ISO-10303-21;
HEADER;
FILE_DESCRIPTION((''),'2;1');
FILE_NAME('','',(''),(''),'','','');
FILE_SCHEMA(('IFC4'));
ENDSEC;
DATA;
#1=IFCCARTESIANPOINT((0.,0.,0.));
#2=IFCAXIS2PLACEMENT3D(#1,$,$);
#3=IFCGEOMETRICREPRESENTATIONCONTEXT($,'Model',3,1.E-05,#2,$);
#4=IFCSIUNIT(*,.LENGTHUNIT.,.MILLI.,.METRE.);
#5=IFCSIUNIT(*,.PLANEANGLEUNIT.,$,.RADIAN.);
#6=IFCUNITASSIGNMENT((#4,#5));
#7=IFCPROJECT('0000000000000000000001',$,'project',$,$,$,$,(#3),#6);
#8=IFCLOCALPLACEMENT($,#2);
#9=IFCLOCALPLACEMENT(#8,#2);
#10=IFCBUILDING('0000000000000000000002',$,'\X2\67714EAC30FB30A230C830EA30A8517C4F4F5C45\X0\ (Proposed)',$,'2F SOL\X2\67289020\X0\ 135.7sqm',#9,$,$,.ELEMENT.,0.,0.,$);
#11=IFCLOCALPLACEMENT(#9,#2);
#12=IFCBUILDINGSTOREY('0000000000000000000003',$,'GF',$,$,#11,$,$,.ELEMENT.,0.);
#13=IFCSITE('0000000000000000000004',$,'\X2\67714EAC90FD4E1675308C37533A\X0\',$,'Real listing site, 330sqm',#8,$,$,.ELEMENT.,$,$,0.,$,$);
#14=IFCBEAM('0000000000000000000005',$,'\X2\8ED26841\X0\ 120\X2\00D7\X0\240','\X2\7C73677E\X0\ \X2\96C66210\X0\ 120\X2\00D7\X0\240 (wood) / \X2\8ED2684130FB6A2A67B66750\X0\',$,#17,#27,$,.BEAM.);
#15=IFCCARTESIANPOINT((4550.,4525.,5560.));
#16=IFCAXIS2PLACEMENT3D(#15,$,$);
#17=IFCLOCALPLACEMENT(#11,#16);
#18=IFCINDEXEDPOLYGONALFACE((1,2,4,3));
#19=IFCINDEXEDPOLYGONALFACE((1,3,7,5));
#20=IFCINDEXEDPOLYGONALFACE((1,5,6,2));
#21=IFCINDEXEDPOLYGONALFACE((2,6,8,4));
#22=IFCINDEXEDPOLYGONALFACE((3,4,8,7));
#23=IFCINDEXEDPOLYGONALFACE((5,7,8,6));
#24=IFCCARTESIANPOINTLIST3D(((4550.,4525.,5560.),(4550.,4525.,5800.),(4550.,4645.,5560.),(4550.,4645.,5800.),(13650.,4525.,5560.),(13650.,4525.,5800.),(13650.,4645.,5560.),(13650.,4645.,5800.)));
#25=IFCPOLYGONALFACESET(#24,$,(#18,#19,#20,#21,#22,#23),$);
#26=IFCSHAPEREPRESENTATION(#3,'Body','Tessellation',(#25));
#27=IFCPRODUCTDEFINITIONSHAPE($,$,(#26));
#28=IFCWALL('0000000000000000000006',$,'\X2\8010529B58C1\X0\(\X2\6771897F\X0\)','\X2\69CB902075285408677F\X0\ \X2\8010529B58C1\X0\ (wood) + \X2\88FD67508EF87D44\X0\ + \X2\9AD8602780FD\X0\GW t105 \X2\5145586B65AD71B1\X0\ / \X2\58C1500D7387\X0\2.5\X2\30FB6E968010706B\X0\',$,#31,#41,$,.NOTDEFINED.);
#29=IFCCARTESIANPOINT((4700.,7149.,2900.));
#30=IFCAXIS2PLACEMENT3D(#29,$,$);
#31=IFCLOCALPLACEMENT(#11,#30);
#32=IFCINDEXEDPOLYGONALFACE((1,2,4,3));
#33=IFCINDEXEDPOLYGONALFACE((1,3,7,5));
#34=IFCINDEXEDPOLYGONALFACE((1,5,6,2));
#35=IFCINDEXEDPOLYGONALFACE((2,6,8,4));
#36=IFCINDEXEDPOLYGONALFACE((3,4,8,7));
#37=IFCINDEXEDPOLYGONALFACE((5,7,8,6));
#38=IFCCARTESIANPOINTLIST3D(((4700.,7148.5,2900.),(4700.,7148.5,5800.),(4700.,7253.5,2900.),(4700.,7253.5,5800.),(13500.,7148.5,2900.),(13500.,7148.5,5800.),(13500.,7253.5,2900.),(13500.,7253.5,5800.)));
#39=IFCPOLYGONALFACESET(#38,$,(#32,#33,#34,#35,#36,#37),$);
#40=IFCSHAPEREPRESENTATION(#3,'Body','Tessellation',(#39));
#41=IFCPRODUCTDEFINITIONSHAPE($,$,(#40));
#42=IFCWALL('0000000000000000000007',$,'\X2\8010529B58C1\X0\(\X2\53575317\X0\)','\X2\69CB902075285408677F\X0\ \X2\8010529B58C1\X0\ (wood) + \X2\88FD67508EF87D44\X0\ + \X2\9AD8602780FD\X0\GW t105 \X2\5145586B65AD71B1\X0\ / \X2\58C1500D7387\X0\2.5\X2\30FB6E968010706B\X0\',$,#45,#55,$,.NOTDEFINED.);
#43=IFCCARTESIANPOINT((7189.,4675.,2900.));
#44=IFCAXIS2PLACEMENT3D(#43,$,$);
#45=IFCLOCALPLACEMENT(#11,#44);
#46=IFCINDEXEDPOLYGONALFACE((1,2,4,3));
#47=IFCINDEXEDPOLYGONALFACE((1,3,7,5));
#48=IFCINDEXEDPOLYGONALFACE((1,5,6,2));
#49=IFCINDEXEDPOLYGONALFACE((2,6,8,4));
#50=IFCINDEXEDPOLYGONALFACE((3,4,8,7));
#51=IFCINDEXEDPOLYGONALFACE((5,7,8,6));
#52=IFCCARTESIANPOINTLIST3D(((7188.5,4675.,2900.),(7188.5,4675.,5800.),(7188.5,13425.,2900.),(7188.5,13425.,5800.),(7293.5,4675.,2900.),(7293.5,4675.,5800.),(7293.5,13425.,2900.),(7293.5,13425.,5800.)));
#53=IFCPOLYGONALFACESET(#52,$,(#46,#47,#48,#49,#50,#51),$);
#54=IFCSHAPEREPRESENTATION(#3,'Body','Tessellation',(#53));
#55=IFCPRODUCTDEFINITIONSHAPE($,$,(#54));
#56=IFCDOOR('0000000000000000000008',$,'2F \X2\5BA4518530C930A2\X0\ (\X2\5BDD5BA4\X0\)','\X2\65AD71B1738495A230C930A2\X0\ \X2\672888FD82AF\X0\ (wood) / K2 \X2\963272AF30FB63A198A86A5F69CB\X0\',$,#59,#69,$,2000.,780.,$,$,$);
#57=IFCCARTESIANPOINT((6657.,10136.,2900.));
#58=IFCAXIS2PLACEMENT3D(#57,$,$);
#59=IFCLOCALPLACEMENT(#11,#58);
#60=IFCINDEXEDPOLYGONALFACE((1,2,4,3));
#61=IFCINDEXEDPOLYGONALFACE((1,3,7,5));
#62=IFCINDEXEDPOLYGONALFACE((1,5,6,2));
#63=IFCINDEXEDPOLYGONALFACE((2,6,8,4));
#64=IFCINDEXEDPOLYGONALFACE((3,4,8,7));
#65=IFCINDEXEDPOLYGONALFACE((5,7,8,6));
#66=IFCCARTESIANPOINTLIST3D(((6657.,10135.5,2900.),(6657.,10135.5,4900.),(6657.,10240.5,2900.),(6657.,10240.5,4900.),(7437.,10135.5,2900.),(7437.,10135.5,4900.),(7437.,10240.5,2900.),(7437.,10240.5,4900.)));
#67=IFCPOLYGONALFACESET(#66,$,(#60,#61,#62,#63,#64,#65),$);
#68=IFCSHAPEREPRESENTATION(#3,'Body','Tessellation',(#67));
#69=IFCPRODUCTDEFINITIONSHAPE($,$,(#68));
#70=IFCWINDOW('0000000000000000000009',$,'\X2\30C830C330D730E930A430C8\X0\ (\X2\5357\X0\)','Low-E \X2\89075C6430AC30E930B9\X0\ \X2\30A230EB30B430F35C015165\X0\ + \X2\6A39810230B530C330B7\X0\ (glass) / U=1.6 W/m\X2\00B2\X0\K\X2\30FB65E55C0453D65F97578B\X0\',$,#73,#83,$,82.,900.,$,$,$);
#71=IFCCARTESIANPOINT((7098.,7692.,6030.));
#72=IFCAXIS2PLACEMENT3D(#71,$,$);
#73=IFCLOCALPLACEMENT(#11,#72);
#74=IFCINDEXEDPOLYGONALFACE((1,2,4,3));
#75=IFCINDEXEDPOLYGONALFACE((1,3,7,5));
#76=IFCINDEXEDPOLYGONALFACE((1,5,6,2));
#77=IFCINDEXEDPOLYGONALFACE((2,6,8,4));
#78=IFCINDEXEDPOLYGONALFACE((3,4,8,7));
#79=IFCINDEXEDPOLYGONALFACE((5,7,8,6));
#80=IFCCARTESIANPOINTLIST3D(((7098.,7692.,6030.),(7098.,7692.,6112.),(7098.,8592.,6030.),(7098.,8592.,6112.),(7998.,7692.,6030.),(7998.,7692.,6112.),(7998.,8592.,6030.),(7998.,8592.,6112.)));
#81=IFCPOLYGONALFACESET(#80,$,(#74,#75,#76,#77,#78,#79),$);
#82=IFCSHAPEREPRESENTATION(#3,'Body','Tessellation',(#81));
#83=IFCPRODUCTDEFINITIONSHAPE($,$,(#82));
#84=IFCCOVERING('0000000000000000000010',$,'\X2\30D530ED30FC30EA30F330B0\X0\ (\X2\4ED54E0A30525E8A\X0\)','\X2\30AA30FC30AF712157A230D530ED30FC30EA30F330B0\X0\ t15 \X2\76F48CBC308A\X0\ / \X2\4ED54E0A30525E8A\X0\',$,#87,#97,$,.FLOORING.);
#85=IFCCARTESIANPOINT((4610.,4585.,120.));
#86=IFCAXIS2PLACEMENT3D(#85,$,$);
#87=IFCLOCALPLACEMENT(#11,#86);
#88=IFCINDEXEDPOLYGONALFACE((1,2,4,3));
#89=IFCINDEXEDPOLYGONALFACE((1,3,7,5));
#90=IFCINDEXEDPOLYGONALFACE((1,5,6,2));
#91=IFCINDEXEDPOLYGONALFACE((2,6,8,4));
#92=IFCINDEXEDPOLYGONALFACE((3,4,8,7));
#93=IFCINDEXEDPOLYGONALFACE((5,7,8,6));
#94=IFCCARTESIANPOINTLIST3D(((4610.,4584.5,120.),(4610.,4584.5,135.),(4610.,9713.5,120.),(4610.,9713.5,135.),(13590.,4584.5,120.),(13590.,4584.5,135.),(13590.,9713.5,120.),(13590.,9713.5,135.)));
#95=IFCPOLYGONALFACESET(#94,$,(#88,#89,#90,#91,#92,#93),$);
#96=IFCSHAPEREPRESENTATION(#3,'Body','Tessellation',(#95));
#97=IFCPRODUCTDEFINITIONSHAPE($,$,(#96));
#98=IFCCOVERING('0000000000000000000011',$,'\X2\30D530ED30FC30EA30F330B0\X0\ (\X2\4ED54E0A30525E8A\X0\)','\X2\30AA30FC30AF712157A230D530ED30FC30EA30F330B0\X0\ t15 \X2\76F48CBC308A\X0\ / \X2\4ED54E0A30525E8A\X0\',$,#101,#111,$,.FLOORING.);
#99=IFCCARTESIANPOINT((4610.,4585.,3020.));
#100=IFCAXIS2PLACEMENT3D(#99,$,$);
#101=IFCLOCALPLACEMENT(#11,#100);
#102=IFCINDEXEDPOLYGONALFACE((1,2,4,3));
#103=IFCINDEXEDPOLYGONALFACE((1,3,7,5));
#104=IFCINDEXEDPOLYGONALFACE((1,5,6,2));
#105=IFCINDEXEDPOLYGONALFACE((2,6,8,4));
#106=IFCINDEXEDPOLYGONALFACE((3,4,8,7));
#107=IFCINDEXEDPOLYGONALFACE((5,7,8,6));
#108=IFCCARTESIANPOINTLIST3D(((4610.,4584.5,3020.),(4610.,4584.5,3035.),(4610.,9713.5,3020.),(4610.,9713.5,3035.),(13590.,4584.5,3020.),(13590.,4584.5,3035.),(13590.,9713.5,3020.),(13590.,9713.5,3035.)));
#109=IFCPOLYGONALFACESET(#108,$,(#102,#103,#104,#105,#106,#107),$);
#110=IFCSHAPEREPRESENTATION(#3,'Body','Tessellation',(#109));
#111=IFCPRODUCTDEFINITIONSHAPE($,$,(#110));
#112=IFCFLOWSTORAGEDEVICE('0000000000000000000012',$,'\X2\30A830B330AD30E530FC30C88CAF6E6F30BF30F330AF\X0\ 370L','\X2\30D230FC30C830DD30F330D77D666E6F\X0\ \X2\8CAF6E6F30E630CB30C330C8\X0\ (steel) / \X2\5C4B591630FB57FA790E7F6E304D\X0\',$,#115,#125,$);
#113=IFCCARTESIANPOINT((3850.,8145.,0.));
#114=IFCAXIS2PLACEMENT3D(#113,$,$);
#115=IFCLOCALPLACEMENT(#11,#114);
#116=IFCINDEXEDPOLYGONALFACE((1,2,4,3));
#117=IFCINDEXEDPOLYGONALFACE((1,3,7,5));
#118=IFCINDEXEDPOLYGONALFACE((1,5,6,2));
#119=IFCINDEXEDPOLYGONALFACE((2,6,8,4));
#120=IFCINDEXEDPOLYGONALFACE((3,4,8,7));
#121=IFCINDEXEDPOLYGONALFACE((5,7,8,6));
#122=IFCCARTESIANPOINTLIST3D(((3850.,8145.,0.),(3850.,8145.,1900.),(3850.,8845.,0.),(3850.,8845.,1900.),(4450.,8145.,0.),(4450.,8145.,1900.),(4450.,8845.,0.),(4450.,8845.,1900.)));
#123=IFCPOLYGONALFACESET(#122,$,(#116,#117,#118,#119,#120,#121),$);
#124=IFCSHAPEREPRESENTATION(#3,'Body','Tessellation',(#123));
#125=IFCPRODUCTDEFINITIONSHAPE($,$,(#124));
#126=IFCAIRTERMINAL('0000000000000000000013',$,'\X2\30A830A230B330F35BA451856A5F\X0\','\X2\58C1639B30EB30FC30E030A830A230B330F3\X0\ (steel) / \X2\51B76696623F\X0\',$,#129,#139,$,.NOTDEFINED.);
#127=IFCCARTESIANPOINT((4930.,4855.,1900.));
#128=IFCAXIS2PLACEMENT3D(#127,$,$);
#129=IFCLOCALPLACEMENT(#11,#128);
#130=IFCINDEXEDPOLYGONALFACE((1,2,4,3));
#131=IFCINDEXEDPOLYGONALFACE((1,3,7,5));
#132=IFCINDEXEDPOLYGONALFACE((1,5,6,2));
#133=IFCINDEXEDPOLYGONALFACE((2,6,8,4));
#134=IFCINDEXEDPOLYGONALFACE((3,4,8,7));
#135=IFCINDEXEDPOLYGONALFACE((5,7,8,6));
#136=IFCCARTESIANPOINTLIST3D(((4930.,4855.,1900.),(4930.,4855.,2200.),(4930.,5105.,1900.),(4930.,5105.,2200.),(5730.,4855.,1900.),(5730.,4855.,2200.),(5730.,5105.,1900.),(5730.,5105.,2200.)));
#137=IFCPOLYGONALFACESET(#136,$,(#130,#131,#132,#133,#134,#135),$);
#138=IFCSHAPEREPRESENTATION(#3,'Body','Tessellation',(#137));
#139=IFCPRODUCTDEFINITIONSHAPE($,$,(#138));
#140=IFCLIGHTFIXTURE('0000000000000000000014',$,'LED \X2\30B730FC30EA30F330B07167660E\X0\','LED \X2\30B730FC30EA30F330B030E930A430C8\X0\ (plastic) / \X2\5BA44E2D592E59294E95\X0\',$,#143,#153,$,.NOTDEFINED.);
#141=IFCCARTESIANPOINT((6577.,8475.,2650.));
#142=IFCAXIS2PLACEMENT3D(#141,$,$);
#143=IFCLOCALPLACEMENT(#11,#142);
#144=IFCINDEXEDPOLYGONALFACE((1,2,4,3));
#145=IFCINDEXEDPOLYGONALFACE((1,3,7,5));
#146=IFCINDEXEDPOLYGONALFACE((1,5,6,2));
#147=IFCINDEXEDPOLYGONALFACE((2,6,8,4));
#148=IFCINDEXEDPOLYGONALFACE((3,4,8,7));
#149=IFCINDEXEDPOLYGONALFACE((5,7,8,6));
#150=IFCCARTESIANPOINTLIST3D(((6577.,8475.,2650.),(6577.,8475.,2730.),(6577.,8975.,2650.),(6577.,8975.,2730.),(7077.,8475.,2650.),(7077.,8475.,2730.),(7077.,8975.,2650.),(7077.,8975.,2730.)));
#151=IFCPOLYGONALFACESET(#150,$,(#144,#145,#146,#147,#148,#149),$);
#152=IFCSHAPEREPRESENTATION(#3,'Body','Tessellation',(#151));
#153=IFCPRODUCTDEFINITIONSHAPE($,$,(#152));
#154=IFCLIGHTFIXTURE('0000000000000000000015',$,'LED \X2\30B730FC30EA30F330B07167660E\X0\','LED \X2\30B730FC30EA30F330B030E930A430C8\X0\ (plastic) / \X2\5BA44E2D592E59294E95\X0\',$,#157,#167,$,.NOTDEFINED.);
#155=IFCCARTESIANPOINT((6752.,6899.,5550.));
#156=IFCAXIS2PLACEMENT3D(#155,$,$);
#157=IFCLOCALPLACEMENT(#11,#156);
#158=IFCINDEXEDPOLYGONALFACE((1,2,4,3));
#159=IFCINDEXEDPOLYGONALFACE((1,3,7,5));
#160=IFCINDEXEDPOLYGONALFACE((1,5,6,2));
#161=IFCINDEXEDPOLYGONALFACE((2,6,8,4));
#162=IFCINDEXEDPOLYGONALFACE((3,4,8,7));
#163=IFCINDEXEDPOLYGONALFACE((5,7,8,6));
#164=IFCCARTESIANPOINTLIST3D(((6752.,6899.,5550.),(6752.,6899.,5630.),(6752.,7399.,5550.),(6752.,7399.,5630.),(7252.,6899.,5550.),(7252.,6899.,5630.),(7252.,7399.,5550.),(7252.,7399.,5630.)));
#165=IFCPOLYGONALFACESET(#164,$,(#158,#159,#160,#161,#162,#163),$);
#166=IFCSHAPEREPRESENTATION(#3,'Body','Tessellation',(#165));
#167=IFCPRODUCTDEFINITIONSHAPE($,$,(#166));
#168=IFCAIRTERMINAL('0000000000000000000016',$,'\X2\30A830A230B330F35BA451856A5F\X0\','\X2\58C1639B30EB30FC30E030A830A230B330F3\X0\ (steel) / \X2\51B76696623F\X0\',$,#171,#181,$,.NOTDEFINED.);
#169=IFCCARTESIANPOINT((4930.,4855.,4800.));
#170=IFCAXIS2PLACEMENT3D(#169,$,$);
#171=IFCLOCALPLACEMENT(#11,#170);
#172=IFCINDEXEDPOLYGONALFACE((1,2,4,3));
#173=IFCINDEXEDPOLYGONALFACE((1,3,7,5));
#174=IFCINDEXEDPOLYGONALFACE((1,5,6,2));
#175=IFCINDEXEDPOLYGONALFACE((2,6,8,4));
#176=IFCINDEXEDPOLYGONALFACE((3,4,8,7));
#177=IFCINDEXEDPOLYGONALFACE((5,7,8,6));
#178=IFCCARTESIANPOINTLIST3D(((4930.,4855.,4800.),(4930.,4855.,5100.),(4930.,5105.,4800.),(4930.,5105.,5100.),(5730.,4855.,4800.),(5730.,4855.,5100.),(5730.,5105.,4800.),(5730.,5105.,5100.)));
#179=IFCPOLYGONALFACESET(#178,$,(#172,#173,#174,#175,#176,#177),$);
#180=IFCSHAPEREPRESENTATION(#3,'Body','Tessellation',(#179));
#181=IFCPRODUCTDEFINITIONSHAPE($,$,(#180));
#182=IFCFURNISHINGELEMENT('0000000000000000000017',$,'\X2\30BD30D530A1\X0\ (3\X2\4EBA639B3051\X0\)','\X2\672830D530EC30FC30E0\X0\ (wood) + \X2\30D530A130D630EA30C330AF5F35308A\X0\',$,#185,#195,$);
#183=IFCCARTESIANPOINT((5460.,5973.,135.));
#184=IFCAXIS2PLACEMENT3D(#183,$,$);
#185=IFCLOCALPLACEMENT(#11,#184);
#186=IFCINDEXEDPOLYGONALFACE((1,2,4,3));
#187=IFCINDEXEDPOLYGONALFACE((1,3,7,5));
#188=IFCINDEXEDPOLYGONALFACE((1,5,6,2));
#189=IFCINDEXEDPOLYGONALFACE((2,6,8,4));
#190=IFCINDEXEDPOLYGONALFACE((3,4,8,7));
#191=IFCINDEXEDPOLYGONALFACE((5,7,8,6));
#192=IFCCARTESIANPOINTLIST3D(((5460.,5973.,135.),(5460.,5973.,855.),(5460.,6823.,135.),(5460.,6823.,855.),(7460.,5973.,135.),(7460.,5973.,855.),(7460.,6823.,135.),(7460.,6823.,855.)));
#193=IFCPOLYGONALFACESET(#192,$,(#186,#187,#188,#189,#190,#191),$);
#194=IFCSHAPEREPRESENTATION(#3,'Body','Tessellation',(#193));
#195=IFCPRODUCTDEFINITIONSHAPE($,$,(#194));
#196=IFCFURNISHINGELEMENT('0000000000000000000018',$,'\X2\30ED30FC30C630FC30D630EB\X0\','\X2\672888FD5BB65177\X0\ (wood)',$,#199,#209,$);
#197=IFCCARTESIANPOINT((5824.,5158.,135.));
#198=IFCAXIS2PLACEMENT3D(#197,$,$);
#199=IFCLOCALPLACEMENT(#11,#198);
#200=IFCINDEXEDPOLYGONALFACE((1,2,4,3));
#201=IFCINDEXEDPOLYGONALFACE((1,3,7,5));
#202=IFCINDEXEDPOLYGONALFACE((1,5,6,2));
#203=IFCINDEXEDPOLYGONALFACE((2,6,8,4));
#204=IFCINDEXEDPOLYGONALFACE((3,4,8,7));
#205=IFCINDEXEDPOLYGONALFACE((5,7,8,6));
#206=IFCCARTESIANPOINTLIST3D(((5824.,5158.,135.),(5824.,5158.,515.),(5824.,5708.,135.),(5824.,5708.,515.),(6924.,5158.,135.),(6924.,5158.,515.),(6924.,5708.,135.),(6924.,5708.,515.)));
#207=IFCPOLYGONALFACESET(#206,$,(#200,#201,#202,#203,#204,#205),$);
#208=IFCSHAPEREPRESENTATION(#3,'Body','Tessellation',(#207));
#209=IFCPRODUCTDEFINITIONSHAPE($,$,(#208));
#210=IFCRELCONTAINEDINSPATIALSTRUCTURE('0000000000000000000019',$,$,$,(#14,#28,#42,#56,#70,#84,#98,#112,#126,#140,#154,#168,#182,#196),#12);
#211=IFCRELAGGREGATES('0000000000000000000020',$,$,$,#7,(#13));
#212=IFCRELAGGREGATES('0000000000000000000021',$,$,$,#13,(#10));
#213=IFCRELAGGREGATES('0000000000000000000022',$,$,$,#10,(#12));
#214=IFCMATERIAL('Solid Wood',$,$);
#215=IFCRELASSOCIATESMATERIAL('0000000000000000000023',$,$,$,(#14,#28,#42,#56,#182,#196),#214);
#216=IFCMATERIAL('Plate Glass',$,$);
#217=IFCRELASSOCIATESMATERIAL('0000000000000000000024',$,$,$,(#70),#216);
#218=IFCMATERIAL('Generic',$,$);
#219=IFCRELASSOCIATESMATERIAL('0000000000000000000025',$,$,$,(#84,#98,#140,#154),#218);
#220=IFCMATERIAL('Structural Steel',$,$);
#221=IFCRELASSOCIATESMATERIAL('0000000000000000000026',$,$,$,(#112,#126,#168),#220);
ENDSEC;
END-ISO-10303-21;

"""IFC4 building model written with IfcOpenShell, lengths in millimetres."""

from ifc_helpers import new_model, si_unit, frame, frame_2d, origin, place, context, project, spatial, rectangle, extrude, material, element, fill, save


model = new_model("IFC4")

# Units and contexts
model_context = context("Model", 3, precision=1e-05, world=origin())
ifc_project = project(units=[si_unit("LENGTHUNIT", "METRE", prefix="MILLI"), si_unit("PLANEANGLEUNIT", "RADIAN")], contexts=[model_context])

# Site, building, storey
site_placement = place(None, origin())
site = spatial("IfcSite", under=ifc_project, at=site_placement, Name="東京都世田谷区", ObjectType="Real listing site, 330sqm", CompositionType="ELEMENT", RefElevation=0.0)
building_placement = place(site_placement, origin())
building = spatial("IfcBuilding", under=site, at=building_placement, Name="東京・アトリエ兼住居 (Proposed)", ObjectType="2F SOL木造 135.7sqm", CompositionType="ELEMENT", ElevationOfRefHeight=0.0, ElevationOfTerrain=0.0)
storey_placement = place(building_placement, origin())
storey = spatial("IfcBuildingStorey", under=building, at=storey_placement, Name="GF", CompositionType="ELEMENT", Elevation=0.0)

# Shared definitions
ifc_material_1 = material(Name="Solid Wood")

# Beam
beam_placement = place(storey_placement, frame((4550.0, 4525.0, 5560.0)))
element("IfcBeam", 1, at=beam_placement, inside=storey, material=ifc_material_1, Name="軒桁 120×240", Description="米松 集成 120×240 (wood) / 軒桁・横架材", PredefinedType="BEAM", context=model_context, shape_type="SweptSolid", body=[
    extrude(rectangle(XDim=9100.0, YDim=120.0, at=frame_2d((4550.0, 60.0))), frame((4550.0, 4525.0, 5560.0)), (0.0, 0.0, 1.0), 240.0),
])

# Wall
wall_1_placement = place(storey_placement, frame((4700.0, 7149.0, 2900.0)))
element("IfcWall", 2, at=wall_1_placement, inside=storey, material=ifc_material_1, Name="耐力壁(東西)", Description="構造用合板 耐力壁 (wood) + 製材軸組 + 高性能GW t105 充填断熱 / 壁倍率2.5・準耐火", PredefinedType="NOTDEFINED", context=model_context, shape_type="SweptSolid", body=[
    extrude(rectangle(XDim=8800.0, YDim=105.0, at=frame_2d((4400.0, 52.0))), frame((4700.0, 7149.0, 2900.0)), (0.0, 0.0, 1.0), 2900.0),
])

# Wall, opening, door
wall_2_placement = place(storey_placement, frame((7189.0, 4675.0, 2900.0)))
wall_2 = element("IfcWall", 3, at=wall_2_placement, inside=storey, material=ifc_material_1, Name="耐力壁(南北)", Description="構造用合板 耐力壁 (wood) + 製材軸組 + 高性能GW t105 充填断熱 / 壁倍率2.5・準耐火", PredefinedType="NOTDEFINED", context=model_context, shape_type="SweptSolid", body=[
    extrude(rectangle(XDim=105.0, YDim=8750.0, at=frame_2d((52.0, 4375.0))), frame((7189.0, 4675.0, 2900.0)), (0.0, 0.0, 1.0), 2900.0),
])
opening_1_placement = place(storey_placement, frame((6657.0, 10136.0, 2900.0)))
opening_1 = element("IfcOpeningElement", 4, at=opening_1_placement, cuts=wall_2, PredefinedType="NOTDEFINED", context=model_context, shape_type="SweptSolid", body=[
    extrude(rectangle(XDim=780.0, YDim=105.0, at=frame_2d((390.0, 52.0))), frame((6657.0, 10136.0, 2900.0)), (0.0, 0.0, 1.0), 2000.0),
])
door_1_placement = place(storey_placement, frame((6657.0, 10136.0, 2900.0)))
door_1 = element("IfcDoor", 5, at=door_1_placement, inside=storey, material=ifc_material_1, Name="2F 室内ドア (寝室)", Description="断熱玄関ドア 木製芯 (wood) / K2 防犯・採風機構", OverallHeight=2000.0, OverallWidth=780.0, context=model_context, shape_type="SweptSolid", body=[
    extrude(rectangle(XDim=780.0, YDim=105.0, at=frame_2d((390.0, 52.0))), frame((6657.0, 10136.0, 2900.0)), (0.0, 0.0, 1.0), 2000.0),
])
fill(opening_1, door_1)

# Window
ifc_material_2 = material(Name="Plate Glass")
window_placement = place(storey_placement, frame((7098.0, 7692.0, 6030.0)))
element("IfcWindow", 6, at=window_placement, inside=storey, material=ifc_material_2, Name="トップライト (南)", Description="Low-E 複層ガラス アルゴン封入 + 樹脂サッシ (glass) / U=1.6 W/m²K・日射取得型", OverallHeight=82.0, OverallWidth=900.0, context=model_context, shape_type="SweptSolid", body=[
    extrude(rectangle(XDim=900.0, YDim=900.0, at=frame_2d((450.0, 450.0))), frame((7098.0, 7692.0, 6030.0)), (0.0, 0.0, 1.0), 82.0),
])

# Coverings
ifc_material_3 = material(Name="Generic")
covering_1_placement = place(storey_placement, frame((4610.0, 4585.0, 120.0)))
element("IfcCovering", 7, at=covering_1_placement, inside=storey, material=ifc_material_3, Name="フローリング (仕上げ床)", Description="オーク無垢フローリング t15 直貼り / 仕上げ床", PredefinedType="FLOORING", context=model_context, shape_type="SweptSolid", body=[
    extrude(rectangle(XDim=8980.0, YDim=5129.0, at=frame_2d((4490.0, 2564.0))), frame((4610.0, 4585.0, 120.0)), (0.0, 0.0, 1.0), 15.0),
])
covering_2_placement = place(storey_placement, frame((4610.0, 4585.0, 3020.0)))
element("IfcCovering", 8, at=covering_2_placement, inside=storey, material=ifc_material_3, Name="フローリング (仕上げ床)", Description="オーク無垢フローリング t15 直貼り / 仕上げ床", PredefinedType="FLOORING", context=model_context, shape_type="SweptSolid", body=[
    extrude(rectangle(XDim=8980.0, YDim=5129.0, at=frame_2d((4490.0, 2564.0))), frame((4610.0, 4585.0, 3020.0)), (0.0, 0.0, 1.0), 15.0),
])

# Flow storage device
ifc_material_4 = material(Name="Structural Steel")
flow_storage_device_placement = place(storey_placement, frame((3850.0, 8145.0, 0.0)))
element("IfcFlowStorageDevice", 9, at=flow_storage_device_placement, inside=storey, material=ifc_material_4, Name="エコキュート貯湯タンク 370L", Description="ヒートポンプ給湯 貯湯ユニット (steel) / 屋外・基礎置き", context=model_context, shape_type="SweptSolid", body=[
    extrude(rectangle(XDim=600.0, YDim=700.0, at=frame_2d((300.0, 350.0))), frame((3850.0, 8145.0, 0.0)), (0.0, 0.0, 1.0), 1900.0),
])

# Air terminal
air_terminal_1_placement = place(storey_placement, frame((4930.0, 4855.0, 1900.0)))
element("IfcAirTerminal", 10, at=air_terminal_1_placement, inside=storey, material=ifc_material_4, Name="エアコン室内機", Description="壁掛ルームエアコン (steel) / 冷暖房", PredefinedType="NOTDEFINED", context=model_context, shape_type="SweptSolid", body=[
    extrude(rectangle(XDim=800.0, YDim=250.0, at=frame_2d((400.0, 125.0))), frame((4930.0, 4855.0, 1900.0)), (0.0, 0.0, 1.0), 300.0),
])

# Light fixtures
light_fixture_1_placement = place(storey_placement, frame((6577.0, 8475.0, 2650.0)))
element("IfcLightFixture", 11, at=light_fixture_1_placement, inside=storey, material=ifc_material_3, Name="LED シーリング照明", Description="LED シーリングライト (plastic) / 室中央天井", PredefinedType="NOTDEFINED", context=model_context, shape_type="SweptSolid", body=[
    extrude(rectangle(XDim=500.0, YDim=500.0, at=frame_2d((250.0, 250.0))), frame((6577.0, 8475.0, 2650.0)), (0.0, 0.0, 1.0), 80.0),
])
light_fixture_2_placement = place(storey_placement, frame((6752.0, 6899.0, 5550.0)))
element("IfcLightFixture", 12, at=light_fixture_2_placement, inside=storey, material=ifc_material_3, Name="LED シーリング照明", Description="LED シーリングライト (plastic) / 室中央天井", PredefinedType="NOTDEFINED", context=model_context, shape_type="SweptSolid", body=[
    extrude(rectangle(XDim=500.0, YDim=500.0, at=frame_2d((250.0, 250.0))), frame((6752.0, 6899.0, 5550.0)), (0.0, 0.0, 1.0), 80.0),
])

# Air terminal
air_terminal_2_placement = place(storey_placement, frame((4930.0, 4855.0, 4800.0)))
element("IfcAirTerminal", 13, at=air_terminal_2_placement, inside=storey, material=ifc_material_4, Name="エアコン室内機", Description="壁掛ルームエアコン (steel) / 冷暖房", PredefinedType="NOTDEFINED", context=model_context, shape_type="SweptSolid", body=[
    extrude(rectangle(XDim=800.0, YDim=250.0, at=frame_2d((400.0, 125.0))), frame((4930.0, 4855.0, 4800.0)), (0.0, 0.0, 1.0), 300.0),
])

# Furnishing elements
furnishing_1_placement = place(storey_placement, frame((5460.0, 5973.0, 135.0)))
element("IfcFurnishingElement", 14, at=furnishing_1_placement, inside=storey, material=ifc_material_1, Name="ソファ (3人掛け)", Description="木フレーム (wood) + ファブリック張り", context=model_context, shape_type="SweptSolid", body=[
    extrude(rectangle(XDim=2000.0, YDim=850.0, at=frame_2d((1000.0, 425.0))), frame((5460.0, 5973.0, 135.0)), (0.0, 0.0, 1.0), 720.0),
])
furnishing_2_placement = place(storey_placement, frame((5824.0, 5158.0, 135.0)))
element("IfcFurnishingElement", 15, at=furnishing_2_placement, inside=storey, material=ifc_material_1, Name="ローテーブル", Description="木製家具 (wood)", context=model_context, shape_type="SweptSolid", body=[
    extrude(rectangle(XDim=1100.0, YDim=550.0, at=frame_2d((550.0, 275.0))), frame((5824.0, 5158.0, 135.0)), (0.0, 0.0, 1.0), 380.0),
])

save(model, "model.ifc")
